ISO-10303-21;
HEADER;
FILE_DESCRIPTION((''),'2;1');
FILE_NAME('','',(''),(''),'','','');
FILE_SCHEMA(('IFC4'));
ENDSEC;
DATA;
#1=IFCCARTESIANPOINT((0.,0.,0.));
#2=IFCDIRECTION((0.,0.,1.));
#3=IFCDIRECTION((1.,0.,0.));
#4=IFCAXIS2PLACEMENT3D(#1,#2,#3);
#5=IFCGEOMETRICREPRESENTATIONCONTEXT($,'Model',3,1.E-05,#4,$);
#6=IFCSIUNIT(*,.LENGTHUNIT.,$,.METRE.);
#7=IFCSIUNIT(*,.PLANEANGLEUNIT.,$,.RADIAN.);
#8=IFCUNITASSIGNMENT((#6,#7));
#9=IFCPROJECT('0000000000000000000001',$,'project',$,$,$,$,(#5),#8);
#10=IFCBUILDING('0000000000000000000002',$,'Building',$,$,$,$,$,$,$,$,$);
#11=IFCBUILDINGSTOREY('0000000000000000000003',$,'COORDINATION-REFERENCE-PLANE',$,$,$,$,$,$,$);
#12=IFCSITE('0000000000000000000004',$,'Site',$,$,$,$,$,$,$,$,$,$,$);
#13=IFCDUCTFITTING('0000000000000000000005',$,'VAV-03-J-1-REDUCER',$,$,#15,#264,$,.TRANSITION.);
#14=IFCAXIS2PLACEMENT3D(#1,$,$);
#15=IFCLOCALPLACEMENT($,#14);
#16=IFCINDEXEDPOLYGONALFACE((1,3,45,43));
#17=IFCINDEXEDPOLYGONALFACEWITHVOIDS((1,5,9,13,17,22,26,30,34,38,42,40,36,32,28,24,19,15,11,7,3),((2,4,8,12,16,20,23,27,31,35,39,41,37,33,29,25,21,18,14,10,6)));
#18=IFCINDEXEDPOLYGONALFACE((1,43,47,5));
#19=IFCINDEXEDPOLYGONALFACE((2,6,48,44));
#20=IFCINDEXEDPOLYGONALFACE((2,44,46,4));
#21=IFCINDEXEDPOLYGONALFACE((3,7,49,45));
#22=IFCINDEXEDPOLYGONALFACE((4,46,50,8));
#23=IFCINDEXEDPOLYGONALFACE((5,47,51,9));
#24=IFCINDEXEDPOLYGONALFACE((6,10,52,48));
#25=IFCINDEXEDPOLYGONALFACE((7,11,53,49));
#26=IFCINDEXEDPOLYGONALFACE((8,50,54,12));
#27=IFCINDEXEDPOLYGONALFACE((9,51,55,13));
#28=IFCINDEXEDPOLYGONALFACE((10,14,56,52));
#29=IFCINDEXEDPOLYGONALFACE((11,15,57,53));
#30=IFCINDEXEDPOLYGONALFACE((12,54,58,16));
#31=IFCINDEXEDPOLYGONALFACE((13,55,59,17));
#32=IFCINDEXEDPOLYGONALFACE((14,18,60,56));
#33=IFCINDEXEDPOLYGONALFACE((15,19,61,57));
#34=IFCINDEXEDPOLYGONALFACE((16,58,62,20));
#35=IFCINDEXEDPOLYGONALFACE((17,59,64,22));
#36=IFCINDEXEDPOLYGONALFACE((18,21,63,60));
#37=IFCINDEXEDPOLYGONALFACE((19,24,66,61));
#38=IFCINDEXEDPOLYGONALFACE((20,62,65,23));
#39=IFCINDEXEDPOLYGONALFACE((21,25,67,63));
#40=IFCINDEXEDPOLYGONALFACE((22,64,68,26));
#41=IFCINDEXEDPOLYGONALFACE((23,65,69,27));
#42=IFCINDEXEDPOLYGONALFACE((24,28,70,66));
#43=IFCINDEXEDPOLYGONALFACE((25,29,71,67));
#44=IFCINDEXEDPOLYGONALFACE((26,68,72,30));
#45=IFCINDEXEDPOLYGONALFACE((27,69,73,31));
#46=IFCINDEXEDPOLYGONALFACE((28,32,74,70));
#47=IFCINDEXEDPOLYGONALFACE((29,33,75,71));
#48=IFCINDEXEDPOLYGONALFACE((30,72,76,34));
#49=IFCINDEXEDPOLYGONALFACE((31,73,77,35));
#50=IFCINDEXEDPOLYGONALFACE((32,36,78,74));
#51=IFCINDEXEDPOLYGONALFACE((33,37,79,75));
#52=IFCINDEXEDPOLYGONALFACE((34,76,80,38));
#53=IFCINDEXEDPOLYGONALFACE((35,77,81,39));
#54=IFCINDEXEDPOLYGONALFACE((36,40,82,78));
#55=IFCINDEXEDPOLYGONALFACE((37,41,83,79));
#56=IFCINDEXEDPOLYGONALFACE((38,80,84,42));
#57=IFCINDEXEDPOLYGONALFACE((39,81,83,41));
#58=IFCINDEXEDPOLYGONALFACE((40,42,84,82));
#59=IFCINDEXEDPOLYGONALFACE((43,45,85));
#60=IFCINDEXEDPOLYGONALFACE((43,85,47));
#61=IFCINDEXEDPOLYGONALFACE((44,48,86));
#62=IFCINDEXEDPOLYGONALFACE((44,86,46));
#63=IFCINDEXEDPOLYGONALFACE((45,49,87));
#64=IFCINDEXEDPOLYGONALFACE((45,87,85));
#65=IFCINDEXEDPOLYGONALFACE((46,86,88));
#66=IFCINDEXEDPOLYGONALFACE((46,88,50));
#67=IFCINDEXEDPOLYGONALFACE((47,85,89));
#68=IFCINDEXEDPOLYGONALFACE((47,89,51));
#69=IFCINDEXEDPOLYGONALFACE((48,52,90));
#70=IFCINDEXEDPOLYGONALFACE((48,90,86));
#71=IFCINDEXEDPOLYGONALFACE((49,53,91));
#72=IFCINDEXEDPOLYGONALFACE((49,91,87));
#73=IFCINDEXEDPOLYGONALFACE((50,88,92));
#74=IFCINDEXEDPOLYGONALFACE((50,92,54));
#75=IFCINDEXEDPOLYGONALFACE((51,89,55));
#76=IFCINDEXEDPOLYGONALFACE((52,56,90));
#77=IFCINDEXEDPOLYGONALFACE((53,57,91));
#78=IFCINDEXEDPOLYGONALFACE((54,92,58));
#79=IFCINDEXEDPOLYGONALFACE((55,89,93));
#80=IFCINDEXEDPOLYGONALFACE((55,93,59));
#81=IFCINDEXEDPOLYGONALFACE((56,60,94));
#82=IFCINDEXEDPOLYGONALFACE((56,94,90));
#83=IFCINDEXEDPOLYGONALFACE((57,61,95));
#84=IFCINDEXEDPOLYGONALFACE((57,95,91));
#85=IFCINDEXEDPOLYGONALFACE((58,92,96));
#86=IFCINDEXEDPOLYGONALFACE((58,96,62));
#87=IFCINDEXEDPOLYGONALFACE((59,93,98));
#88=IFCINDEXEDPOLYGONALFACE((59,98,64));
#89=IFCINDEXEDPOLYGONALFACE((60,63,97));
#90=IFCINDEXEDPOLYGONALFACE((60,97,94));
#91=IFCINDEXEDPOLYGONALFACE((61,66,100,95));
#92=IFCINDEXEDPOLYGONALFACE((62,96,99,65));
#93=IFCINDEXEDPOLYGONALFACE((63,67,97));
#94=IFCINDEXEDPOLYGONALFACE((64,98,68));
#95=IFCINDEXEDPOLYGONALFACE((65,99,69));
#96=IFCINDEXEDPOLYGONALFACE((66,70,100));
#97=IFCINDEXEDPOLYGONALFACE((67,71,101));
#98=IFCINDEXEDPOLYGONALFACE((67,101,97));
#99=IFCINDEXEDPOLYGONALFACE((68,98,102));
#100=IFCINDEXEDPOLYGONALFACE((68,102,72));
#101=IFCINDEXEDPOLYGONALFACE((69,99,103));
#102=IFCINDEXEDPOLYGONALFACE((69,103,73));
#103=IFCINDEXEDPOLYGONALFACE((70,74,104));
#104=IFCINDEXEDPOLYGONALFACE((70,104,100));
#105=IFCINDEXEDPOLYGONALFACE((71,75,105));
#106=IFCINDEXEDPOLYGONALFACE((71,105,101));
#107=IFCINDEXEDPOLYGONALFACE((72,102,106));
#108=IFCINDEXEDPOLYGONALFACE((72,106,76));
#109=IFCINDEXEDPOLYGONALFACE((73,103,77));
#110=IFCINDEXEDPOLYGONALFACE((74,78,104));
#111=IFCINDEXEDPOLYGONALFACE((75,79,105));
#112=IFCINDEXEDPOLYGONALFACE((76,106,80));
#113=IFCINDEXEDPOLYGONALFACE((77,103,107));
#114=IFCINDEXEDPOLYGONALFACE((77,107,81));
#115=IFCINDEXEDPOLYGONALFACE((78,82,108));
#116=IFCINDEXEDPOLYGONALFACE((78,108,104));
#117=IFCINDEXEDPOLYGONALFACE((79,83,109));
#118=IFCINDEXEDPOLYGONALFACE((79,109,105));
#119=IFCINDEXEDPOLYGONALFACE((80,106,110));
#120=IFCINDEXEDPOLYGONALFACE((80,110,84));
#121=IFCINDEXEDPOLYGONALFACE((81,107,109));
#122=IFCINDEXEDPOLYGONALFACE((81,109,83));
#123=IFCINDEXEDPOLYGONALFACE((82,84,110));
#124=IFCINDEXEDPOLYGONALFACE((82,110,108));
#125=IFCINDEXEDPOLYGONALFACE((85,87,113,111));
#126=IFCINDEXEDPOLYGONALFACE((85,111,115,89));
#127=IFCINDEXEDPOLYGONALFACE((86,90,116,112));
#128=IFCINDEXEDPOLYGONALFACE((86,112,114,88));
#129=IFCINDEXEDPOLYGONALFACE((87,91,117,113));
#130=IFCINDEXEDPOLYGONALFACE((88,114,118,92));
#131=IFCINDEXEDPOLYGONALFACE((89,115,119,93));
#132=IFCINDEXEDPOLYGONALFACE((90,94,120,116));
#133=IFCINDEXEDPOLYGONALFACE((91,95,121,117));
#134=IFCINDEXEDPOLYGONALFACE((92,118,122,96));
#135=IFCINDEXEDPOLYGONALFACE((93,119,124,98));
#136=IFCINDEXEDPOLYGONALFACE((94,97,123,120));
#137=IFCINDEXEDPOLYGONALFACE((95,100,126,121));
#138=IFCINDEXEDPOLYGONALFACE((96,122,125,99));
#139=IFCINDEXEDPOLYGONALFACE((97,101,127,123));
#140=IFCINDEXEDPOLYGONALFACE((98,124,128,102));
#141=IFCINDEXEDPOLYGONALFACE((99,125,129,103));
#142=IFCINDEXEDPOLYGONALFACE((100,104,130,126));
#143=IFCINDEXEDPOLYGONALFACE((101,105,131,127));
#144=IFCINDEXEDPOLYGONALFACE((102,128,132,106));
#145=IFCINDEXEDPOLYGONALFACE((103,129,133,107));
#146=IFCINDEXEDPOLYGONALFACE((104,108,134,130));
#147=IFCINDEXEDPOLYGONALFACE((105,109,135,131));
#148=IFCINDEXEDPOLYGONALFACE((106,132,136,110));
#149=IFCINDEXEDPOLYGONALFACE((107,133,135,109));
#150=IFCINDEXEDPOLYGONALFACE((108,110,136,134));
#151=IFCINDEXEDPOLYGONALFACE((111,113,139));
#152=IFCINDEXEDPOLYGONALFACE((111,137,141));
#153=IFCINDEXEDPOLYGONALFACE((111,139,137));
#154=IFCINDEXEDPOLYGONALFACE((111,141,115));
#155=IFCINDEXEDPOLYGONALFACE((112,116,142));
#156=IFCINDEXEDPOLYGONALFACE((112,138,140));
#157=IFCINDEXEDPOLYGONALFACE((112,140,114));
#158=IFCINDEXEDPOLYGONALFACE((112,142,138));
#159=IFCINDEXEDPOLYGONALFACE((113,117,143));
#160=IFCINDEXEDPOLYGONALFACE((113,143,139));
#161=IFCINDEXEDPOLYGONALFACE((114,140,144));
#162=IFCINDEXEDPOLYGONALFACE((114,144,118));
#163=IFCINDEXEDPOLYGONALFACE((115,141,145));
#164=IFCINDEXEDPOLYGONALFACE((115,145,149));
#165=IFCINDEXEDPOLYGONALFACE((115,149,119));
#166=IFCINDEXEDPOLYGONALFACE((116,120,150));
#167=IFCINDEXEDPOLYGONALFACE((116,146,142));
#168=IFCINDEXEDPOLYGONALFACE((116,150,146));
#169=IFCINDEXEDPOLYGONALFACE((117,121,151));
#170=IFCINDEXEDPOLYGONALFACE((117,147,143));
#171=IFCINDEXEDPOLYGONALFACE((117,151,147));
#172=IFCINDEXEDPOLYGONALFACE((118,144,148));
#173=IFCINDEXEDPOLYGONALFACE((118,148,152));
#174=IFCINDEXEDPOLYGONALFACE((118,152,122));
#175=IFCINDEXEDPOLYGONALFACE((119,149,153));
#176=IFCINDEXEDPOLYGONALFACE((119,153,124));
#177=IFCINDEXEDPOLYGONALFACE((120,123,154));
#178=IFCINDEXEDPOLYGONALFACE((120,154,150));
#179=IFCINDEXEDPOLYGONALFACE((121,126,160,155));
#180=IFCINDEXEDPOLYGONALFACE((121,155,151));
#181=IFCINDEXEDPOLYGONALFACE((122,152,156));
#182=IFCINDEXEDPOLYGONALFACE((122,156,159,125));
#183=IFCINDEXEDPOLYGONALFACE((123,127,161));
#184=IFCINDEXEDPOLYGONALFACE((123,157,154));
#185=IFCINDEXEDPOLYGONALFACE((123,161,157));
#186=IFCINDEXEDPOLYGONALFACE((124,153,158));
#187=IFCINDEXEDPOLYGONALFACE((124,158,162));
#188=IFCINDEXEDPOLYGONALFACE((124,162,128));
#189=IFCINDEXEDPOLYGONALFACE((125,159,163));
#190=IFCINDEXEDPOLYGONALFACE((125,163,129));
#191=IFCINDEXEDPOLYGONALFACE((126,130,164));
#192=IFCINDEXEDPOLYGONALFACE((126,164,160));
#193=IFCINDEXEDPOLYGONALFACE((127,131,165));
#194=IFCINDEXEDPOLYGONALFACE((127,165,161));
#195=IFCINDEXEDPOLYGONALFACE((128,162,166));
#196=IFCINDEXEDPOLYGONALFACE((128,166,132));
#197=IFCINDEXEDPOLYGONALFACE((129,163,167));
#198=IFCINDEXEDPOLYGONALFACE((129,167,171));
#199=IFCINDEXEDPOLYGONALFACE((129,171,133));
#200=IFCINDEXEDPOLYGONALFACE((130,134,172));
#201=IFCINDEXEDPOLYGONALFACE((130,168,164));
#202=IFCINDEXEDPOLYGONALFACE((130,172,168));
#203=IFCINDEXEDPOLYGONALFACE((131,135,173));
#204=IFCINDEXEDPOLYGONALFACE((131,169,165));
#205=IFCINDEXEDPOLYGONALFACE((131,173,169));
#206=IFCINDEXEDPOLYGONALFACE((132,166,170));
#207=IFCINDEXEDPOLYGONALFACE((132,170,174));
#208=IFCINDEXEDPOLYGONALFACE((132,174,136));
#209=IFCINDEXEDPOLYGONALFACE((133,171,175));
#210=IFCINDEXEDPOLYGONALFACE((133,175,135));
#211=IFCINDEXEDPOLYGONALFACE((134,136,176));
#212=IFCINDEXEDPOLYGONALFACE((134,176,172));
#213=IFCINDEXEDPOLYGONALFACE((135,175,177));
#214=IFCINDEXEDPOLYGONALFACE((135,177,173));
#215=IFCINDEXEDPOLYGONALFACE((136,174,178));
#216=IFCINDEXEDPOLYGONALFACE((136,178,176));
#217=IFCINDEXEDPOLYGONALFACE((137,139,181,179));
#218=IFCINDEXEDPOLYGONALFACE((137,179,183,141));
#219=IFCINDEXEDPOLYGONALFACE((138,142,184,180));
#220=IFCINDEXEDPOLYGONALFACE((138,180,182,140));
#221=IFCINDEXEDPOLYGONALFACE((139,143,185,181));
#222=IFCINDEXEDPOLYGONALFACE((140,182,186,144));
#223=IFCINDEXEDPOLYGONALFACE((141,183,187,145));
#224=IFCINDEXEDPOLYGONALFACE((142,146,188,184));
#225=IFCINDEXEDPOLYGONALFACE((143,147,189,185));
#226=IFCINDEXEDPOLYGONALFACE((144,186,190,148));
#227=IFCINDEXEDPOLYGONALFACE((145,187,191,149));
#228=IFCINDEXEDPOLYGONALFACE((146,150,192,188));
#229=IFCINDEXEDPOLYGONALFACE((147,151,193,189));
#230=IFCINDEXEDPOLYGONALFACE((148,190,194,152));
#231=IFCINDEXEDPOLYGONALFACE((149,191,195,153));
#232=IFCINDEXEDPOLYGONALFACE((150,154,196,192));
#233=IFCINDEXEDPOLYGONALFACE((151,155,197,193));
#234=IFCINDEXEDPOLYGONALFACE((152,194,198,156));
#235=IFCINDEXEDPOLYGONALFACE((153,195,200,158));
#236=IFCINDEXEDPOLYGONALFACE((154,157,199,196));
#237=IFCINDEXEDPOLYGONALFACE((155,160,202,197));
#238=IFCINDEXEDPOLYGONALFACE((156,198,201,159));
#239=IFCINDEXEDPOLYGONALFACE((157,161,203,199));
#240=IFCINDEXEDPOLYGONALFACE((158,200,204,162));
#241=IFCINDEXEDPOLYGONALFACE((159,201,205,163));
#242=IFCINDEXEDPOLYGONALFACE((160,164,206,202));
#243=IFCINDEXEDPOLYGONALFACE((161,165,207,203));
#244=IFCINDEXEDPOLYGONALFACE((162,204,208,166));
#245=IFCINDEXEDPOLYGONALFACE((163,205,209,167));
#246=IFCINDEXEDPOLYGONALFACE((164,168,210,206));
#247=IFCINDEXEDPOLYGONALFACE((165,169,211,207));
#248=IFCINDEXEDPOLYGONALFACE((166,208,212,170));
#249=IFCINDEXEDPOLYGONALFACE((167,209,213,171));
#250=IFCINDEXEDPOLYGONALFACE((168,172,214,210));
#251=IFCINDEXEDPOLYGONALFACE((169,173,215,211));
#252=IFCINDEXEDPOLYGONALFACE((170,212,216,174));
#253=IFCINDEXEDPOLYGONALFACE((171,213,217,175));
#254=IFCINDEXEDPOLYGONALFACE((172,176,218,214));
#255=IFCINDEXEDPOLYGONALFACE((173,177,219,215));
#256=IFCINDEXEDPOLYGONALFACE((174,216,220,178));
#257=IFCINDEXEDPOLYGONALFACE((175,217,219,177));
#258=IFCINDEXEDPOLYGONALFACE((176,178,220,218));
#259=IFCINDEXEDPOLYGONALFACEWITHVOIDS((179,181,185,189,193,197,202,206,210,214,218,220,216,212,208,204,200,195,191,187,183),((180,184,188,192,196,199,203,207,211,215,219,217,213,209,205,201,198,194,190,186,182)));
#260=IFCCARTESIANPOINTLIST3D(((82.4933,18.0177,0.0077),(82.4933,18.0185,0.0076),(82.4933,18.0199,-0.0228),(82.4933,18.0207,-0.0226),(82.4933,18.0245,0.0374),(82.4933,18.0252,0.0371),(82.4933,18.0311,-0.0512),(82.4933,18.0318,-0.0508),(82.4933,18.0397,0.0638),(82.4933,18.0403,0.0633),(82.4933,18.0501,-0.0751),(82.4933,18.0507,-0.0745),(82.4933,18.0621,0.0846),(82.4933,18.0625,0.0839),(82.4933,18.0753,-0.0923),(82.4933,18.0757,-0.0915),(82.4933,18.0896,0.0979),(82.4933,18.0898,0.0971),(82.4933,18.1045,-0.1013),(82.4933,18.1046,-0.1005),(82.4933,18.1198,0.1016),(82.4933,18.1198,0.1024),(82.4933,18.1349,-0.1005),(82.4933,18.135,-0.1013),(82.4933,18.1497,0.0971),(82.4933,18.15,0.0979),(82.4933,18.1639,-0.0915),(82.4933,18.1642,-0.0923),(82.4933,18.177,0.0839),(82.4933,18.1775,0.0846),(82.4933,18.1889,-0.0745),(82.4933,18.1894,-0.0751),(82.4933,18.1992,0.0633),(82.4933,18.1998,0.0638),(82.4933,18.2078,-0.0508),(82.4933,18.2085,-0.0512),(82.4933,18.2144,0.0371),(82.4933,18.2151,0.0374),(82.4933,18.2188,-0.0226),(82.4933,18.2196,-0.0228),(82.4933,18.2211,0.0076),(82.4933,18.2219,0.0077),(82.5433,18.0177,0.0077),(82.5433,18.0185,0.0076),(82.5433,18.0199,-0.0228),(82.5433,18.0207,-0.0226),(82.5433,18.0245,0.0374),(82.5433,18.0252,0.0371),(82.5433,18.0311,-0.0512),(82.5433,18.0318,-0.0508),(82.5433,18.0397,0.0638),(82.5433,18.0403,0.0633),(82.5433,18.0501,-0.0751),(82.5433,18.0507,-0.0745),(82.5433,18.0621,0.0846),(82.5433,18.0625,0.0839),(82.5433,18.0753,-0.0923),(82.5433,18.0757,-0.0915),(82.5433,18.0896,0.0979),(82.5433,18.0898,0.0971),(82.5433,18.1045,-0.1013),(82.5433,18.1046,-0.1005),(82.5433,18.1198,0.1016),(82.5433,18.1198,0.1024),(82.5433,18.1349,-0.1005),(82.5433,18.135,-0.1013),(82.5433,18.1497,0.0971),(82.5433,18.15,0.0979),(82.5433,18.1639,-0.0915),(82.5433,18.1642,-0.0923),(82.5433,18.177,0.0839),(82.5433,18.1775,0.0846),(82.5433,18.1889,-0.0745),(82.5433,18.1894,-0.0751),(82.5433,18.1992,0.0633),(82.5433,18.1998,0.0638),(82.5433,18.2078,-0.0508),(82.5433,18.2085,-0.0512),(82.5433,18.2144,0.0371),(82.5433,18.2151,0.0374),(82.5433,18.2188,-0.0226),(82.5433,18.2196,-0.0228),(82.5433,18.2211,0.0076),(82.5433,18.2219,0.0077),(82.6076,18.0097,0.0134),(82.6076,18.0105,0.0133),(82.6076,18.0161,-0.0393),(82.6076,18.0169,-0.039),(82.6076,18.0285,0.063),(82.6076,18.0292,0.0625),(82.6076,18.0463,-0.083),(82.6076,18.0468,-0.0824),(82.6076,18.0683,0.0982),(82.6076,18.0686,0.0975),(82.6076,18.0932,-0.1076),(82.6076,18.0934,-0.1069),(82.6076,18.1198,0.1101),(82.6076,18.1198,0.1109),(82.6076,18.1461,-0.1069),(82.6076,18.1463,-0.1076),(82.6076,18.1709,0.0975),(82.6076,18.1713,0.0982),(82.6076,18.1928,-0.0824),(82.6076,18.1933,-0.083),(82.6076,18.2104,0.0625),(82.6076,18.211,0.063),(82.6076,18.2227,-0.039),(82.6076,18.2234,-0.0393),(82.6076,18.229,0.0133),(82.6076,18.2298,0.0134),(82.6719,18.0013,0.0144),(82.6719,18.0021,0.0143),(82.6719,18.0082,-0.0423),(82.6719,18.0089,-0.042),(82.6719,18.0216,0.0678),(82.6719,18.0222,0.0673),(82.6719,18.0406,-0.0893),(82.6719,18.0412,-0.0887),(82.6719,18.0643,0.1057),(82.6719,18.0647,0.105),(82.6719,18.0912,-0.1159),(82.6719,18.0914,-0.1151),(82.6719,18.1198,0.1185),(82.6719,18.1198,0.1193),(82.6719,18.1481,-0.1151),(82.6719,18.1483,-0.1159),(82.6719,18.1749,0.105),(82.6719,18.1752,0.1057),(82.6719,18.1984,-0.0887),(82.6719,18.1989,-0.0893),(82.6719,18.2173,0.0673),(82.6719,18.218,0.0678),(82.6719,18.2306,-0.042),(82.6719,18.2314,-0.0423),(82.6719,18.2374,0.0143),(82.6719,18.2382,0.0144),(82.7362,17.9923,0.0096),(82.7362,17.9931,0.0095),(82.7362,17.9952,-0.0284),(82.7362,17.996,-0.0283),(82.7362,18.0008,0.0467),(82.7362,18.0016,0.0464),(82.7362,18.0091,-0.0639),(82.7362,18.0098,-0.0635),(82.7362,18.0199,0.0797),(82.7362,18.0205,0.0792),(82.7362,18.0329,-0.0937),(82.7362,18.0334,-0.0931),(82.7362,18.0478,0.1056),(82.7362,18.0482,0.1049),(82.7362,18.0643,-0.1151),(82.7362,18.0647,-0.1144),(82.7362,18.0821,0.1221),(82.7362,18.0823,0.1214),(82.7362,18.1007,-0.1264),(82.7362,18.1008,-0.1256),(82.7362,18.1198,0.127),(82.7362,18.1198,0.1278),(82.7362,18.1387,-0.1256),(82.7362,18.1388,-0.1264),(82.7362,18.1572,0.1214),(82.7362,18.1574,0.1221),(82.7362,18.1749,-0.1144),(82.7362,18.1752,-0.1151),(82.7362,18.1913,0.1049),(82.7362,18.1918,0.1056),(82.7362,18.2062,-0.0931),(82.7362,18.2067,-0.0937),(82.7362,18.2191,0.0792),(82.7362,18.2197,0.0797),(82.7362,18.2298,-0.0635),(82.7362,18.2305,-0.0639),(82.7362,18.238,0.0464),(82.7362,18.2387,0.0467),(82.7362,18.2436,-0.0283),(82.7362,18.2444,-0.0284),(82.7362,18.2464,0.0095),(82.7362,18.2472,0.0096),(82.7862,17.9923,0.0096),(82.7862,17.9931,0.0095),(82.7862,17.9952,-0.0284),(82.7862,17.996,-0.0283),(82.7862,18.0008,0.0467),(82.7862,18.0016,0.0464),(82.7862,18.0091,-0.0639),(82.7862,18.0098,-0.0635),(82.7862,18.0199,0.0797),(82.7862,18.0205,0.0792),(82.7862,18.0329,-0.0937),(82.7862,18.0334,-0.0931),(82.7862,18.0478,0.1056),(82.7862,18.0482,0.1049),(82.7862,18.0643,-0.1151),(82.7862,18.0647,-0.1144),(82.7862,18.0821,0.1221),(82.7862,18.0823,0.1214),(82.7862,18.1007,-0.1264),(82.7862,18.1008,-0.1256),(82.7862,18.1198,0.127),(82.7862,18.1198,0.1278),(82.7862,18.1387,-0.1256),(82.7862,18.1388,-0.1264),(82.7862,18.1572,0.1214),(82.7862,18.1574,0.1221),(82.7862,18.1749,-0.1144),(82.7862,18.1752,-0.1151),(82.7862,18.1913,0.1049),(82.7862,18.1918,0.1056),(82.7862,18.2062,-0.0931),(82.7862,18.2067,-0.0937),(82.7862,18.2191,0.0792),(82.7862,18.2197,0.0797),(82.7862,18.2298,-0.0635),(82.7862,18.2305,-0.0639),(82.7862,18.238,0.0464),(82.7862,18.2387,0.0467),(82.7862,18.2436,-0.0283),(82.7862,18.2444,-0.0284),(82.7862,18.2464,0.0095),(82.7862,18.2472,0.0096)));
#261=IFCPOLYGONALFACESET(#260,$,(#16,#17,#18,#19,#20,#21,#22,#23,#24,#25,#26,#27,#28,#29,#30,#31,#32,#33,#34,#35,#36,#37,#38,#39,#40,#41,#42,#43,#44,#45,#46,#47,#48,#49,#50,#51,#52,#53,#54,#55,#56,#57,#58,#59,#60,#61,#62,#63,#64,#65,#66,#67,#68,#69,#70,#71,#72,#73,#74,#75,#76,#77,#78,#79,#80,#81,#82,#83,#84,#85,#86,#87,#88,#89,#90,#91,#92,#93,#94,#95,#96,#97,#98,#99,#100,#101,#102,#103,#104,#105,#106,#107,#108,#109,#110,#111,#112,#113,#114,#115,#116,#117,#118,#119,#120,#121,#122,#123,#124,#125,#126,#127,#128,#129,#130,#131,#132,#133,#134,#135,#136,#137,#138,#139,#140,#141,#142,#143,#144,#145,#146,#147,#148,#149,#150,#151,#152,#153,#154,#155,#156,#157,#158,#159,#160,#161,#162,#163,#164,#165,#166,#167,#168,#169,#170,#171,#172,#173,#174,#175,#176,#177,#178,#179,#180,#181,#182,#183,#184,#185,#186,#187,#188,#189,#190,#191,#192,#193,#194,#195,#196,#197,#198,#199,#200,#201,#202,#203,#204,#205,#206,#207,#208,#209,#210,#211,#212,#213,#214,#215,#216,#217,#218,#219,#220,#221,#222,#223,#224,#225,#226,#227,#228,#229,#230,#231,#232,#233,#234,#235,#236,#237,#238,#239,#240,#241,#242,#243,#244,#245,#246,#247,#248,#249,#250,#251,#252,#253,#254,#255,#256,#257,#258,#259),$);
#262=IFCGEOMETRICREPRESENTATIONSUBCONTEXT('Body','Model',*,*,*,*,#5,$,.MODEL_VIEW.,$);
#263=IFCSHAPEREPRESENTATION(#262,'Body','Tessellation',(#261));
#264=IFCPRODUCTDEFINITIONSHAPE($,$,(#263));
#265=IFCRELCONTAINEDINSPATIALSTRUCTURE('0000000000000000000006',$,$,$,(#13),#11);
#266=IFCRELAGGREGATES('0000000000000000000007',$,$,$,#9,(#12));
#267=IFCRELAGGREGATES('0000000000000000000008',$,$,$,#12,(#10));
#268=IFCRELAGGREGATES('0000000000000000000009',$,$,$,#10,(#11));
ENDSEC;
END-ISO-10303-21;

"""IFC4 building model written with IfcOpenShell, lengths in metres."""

from ifc_helpers import new_model, entity, si_unit, frame, origin_with_axes, place, context, subcontext, project, spatial, element, save


model = new_model("IFC4")

# Units and contexts
model_context_1 = context("Model", 3, precision=1e-05, world=origin_with_axes())
body_context_1 = subcontext(model_context_1, "Body", "Model", "MODEL_VIEW")
ifc_project = project(units=[si_unit("LENGTHUNIT", "METRE"), si_unit("PLANEANGLEUNIT", "RADIAN")], contexts=[model_context_1])

# Site, building, storey
site = spatial("IfcSite", under=ifc_project, Name="Site")
building = spatial("IfcBuilding", under=site, Name="Building")
storey = spatial("IfcBuildingStorey", under=building, Name="COORDINATION-REFERENCE-PLANE")

# Duct fitting
for number, where, z_axis, x_axis, name in (
    (1, (82.7862, 18.1198, 0.0), (0.0, -1.0, 0.0), (0.0, 0.0, 1.0), "VAV-03-J-1-REDUCER"),
):
    element("IfcDuctFitting", number, at=place(None, frame(where, z_axis=z_axis, x_axis=x_axis)), inside=storey, Name=name, PredefinedType="TRANSITION", context=body_context_1, shape_type="SweptSolid", body=[
        entity("IfcRevolvedAreaSolid", entity("IfcArbitraryClosedProfileDef", "AREA", None, entity("IfcPolyline", [entity("IfcCartesianPoint", [0.1278, 0.0]), entity("IfcCartesianPoint", [0.1278, 0.05]), entity("IfcCartesianPoint", [0.1024, 0.2429]), entity("IfcCartesianPoint", [0.1024, 0.2929]), entity("IfcCartesianPoint", [0.1016, 0.2929]), entity("IfcCartesianPoint", [0.1016, 0.2429]), entity("IfcCartesianPoint", [0.127, 0.05]), entity("IfcCartesianPoint", [0.127, 0.0]), entity("IfcCartesianPoint", [0.1278, 0.0])])), entity("IfcAxis2Placement3D", entity("IfcCartesianPoint", [0.0, 0.0, 0.0])), entity("IfcAxis1Placement", entity("IfcCartesianPoint", [0.0, 0.0, 0.0]), entity("IfcDirection", [0.0, 1.0, 0.0])), 6.283185),
    ])

save(model, "model.ifc")
